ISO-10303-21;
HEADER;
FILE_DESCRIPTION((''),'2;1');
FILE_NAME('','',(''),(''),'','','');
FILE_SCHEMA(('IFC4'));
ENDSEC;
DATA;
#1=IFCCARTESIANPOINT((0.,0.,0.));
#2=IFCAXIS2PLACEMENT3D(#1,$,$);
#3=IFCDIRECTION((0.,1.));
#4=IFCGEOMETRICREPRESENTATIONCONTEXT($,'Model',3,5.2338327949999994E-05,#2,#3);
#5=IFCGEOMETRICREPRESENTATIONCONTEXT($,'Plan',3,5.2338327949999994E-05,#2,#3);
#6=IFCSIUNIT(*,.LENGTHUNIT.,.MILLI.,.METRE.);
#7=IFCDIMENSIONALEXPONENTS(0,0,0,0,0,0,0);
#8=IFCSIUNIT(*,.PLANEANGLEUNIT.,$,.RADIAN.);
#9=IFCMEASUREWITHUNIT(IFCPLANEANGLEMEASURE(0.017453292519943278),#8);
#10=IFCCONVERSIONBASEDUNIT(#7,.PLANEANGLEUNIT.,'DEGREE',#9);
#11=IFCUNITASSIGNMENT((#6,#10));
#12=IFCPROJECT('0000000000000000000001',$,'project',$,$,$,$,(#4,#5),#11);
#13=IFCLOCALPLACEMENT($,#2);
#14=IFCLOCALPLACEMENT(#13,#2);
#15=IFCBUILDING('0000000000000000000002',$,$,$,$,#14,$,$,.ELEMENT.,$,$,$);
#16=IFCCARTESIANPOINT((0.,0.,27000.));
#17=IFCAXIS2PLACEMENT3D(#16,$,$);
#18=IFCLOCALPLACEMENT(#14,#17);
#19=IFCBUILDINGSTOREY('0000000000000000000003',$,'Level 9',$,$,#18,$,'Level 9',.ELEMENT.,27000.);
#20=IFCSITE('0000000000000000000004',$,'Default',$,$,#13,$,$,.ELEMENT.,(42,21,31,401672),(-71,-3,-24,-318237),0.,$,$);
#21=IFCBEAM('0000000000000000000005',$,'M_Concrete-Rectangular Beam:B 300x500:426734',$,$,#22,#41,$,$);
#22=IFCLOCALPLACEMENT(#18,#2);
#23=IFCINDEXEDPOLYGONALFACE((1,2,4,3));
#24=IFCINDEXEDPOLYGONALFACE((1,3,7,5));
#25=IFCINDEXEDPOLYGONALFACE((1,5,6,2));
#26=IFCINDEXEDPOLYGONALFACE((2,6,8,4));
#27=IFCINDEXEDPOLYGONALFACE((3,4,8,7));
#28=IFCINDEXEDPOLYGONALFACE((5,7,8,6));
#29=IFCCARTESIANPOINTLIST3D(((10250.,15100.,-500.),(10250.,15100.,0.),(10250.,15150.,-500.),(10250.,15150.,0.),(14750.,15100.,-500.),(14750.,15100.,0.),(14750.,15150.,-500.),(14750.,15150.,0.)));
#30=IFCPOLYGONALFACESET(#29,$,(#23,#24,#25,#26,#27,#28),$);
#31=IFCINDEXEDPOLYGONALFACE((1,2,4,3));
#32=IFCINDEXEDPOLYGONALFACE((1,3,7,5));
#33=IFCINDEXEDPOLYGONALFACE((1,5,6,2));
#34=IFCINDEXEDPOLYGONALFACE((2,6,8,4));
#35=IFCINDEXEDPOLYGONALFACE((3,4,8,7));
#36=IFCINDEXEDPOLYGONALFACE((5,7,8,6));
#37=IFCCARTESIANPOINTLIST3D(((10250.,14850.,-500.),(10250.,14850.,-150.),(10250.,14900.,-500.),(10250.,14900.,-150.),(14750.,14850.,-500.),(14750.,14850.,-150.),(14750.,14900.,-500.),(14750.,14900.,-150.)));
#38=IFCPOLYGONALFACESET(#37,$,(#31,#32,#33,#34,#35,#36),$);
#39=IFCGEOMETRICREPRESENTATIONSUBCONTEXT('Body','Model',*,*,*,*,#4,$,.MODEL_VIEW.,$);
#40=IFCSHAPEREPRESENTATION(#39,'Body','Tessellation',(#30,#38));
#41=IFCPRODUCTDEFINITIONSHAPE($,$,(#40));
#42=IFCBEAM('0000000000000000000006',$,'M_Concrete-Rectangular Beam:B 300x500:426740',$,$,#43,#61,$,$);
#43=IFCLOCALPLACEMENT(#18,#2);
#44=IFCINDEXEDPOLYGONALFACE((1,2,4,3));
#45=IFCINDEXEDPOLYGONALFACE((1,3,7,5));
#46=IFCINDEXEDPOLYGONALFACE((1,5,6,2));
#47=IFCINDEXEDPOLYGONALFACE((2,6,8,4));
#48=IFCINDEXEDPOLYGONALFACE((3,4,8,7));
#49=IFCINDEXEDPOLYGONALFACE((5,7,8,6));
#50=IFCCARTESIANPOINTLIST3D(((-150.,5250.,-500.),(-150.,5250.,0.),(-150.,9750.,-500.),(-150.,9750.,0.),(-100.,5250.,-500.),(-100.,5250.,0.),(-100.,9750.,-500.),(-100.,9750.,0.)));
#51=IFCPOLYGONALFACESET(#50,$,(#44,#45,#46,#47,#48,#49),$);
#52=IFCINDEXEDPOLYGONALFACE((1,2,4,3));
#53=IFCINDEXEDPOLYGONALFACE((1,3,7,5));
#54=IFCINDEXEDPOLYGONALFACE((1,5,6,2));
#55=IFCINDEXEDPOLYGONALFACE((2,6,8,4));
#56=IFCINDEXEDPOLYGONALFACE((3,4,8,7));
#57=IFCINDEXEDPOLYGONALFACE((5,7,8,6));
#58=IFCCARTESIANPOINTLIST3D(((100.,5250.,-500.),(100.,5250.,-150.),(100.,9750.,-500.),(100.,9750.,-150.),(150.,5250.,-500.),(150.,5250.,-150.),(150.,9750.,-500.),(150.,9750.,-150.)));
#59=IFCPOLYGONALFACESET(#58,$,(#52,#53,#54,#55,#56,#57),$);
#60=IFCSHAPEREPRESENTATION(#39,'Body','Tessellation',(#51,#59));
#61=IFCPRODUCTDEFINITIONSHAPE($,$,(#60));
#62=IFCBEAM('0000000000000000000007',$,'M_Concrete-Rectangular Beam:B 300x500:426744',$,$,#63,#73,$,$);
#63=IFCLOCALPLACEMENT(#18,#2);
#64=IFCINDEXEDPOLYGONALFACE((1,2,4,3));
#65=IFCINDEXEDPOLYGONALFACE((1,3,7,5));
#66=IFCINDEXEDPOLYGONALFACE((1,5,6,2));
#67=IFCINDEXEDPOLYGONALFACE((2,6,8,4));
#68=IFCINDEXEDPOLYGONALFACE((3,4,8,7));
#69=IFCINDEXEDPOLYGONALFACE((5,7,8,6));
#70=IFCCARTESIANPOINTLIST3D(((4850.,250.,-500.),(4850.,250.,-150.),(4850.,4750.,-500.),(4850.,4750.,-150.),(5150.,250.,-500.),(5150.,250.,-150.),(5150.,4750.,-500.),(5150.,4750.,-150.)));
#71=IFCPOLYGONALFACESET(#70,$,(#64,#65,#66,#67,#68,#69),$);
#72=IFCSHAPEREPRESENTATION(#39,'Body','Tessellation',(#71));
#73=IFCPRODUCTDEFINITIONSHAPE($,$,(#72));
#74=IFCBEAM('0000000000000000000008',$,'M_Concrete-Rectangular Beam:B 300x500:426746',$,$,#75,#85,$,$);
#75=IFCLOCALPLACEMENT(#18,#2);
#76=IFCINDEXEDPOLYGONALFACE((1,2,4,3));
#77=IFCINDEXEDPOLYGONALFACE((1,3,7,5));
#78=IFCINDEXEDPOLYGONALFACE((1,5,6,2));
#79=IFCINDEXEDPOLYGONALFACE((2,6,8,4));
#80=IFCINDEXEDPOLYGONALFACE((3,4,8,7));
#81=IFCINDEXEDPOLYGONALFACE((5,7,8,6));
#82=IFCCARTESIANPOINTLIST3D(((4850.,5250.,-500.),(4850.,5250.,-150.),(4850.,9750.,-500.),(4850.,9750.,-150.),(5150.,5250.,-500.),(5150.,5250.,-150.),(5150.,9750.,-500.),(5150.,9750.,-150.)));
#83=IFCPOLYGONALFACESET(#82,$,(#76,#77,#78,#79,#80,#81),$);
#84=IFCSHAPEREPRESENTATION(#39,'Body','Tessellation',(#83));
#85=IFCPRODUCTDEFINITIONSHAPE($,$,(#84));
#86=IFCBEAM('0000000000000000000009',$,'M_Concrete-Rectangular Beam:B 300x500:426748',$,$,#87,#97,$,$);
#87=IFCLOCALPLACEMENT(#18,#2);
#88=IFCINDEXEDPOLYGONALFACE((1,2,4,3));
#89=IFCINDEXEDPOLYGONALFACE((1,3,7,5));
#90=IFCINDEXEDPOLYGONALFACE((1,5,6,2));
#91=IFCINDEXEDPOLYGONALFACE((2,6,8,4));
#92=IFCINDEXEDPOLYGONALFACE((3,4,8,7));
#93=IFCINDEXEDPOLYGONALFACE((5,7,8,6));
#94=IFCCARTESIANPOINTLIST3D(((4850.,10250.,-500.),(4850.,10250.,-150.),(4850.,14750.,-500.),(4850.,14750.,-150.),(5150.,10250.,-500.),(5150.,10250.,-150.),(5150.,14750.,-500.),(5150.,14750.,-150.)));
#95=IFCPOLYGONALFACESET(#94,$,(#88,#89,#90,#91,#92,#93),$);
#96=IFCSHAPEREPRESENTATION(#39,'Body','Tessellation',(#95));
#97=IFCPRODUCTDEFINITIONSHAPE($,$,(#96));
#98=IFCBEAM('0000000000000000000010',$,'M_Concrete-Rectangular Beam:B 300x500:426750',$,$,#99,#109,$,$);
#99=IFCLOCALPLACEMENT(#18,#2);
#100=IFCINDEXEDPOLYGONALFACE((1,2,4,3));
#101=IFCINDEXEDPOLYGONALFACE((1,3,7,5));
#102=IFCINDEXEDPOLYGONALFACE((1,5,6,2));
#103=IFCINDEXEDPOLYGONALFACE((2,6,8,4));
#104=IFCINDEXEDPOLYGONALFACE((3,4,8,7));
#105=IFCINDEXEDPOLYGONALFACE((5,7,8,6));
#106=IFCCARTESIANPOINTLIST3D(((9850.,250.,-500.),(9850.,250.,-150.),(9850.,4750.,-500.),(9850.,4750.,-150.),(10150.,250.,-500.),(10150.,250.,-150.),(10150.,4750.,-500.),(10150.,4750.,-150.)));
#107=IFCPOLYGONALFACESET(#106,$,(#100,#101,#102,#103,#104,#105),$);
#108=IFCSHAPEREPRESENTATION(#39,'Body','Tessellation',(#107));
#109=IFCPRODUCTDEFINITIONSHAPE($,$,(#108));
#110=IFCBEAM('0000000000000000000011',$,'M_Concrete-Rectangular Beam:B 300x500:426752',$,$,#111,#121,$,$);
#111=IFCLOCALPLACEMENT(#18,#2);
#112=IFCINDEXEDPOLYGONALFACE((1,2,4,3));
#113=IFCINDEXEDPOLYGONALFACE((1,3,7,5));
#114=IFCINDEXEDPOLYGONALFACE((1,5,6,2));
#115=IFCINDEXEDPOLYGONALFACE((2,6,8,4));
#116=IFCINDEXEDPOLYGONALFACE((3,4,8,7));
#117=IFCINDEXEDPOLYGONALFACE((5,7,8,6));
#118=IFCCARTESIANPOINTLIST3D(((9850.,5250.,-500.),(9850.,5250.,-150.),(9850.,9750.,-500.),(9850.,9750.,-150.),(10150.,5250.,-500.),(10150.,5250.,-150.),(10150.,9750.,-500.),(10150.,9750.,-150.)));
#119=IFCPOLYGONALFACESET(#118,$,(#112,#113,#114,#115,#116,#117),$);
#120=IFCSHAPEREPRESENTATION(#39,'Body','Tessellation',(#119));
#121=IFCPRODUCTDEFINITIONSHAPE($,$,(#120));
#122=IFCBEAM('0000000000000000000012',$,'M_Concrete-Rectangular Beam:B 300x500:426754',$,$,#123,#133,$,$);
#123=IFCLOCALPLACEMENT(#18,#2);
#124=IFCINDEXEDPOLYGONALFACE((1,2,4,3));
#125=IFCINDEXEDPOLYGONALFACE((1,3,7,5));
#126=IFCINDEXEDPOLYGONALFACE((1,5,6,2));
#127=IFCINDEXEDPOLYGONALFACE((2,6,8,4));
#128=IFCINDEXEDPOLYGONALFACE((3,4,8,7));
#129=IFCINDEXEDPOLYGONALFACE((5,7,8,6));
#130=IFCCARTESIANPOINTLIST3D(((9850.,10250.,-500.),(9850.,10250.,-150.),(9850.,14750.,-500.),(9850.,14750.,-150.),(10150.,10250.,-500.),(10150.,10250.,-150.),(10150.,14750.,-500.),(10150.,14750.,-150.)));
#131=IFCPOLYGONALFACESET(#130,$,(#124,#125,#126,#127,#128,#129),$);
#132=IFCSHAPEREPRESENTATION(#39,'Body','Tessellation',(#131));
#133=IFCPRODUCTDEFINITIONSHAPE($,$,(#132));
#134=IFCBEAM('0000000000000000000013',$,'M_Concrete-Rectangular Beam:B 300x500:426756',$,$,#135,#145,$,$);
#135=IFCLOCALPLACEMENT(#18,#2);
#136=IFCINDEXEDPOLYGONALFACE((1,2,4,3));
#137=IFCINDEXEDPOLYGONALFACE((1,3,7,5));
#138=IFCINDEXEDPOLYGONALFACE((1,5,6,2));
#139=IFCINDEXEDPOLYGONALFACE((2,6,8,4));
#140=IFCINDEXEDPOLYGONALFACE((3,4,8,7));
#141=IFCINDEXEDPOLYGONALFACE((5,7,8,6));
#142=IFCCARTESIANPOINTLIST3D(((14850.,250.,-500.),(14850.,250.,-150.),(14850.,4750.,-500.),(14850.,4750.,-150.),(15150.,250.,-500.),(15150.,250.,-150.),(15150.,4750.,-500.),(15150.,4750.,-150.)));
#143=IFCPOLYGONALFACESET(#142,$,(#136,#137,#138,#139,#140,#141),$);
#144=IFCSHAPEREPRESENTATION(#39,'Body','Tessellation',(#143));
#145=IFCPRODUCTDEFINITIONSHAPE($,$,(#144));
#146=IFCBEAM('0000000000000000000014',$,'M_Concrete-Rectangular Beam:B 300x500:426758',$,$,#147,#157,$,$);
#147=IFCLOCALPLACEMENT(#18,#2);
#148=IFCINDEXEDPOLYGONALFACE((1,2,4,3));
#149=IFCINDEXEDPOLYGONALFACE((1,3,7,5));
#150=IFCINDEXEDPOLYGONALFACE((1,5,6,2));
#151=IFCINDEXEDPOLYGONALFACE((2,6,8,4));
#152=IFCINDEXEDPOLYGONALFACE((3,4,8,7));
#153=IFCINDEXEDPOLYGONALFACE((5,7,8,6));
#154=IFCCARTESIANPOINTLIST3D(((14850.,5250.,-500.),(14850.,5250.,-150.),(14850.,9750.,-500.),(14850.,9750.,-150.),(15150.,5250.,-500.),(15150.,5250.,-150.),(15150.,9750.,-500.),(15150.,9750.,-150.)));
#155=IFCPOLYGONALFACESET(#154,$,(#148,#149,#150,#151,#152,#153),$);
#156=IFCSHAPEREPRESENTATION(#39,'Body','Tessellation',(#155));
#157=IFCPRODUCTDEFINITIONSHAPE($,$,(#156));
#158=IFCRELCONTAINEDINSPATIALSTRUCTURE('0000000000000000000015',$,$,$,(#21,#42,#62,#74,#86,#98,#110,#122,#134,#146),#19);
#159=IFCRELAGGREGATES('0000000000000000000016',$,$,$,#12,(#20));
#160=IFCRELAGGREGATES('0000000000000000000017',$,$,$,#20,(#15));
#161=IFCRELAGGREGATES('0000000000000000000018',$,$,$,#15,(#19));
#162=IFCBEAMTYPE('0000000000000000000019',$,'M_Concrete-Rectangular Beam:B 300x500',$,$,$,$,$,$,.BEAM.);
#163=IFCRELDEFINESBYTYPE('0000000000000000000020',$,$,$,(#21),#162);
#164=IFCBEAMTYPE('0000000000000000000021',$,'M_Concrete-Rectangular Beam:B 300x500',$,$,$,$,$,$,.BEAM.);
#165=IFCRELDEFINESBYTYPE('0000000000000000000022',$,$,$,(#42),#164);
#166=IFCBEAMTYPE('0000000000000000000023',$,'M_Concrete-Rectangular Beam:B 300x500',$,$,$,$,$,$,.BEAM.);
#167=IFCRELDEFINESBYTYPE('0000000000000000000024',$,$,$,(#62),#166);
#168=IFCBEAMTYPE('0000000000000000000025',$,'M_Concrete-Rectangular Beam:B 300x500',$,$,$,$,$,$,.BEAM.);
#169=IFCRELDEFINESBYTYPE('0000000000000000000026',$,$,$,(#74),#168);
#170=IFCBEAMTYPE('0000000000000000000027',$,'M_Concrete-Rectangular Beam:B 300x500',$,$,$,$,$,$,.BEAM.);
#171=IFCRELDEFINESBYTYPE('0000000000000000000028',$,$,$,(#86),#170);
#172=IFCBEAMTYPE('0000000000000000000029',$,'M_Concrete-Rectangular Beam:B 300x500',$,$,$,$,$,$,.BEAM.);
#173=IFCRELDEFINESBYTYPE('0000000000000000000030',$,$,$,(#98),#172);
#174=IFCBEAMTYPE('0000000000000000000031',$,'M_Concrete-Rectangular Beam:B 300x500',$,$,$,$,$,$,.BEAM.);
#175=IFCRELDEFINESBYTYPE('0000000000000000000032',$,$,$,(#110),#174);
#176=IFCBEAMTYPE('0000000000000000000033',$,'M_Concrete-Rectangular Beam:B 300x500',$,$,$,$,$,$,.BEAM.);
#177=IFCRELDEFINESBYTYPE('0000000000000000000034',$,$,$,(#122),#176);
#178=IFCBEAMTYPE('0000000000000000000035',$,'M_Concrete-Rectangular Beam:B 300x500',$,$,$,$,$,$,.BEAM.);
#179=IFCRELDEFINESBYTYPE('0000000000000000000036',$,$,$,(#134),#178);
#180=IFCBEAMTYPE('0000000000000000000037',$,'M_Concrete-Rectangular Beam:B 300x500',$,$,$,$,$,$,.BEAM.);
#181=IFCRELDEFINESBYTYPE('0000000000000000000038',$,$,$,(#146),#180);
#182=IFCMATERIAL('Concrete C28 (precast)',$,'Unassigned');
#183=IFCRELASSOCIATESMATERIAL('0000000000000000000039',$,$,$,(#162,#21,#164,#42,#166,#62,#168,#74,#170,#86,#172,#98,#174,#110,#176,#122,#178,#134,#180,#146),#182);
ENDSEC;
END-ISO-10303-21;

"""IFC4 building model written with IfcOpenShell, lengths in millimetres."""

from ifc_helpers import new_model, entity, si_unit, converted_unit, direction, frame, origin, place, context, subcontext, project, spatial, indexed_curve, outline, extrude, source, transform, mapped, material, type_object, type_shapes, element, save


model = new_model("IFC4")

# Units and contexts
model_context = context("Model", 3, precision=5.2338327949999994e-05, world=origin(), true_north=direction((0.0, 1.0)))
plan_context = context("Plan", 3, precision=5.2338327949999994e-05, world=origin(), true_north=direction((0.0, 1.0)))
body_context = subcontext(model_context, "Body", "Model", "MODEL_VIEW")
ifc_project = project(units=[si_unit("LENGTHUNIT", "METRE", prefix="MILLI"), converted_unit("PLANEANGLEUNIT", "DEGREE", entity("IfcPlaneAngleMeasure", 0.017453292519943278), si_unit("PLANEANGLEUNIT", "RADIAN"), dimensions=[0, 0, 0, 0, 0, 0, 0])], contexts=[model_context, plan_context])

# Site, building, storey
site_placement = place(None, origin())
site = spatial("IfcSite", under=ifc_project, at=site_placement, Name="Default", CompositionType="ELEMENT", RefLatitude=(42, 21, 31, 401672), RefLongitude=(-71, -3, -24, -318237), RefElevation=0.0)
building_placement = place(site_placement, origin())
building = spatial("IfcBuilding", under=site, at=building_placement, CompositionType="ELEMENT")
storey_placement = place(building_placement, frame((0.0, 0.0, 27000.0)))
storey = spatial("IfcBuildingStorey", under=building, at=storey_placement, Name="Level 9", LongName="Level 9", CompositionType="ELEMENT", Elevation=27000.0)

# Beams
ifc_material = material(Name="Concrete C28 (precast)", Category="Unassigned")
beam_type_1 = type_object("IfcBeamType", Name="M_Concrete-Rectangular Beam:B 300x500", PredefinedType="BEAM", material=ifc_material)
shared_shape_1 = source(origin(), body_context, "Body", "SweptSolid", [
    extrude(outline(indexed_curve([(-250.0, -25.0), (250.0, -25.0), (250.0, 25.0), (-250.0, 25.0), (-250.0, -25.0)], self_intersect=False)), frame((10250.0, 15125.0, 26750.0), z_axis=(1.0, 0.0, 0.0), x_axis=(0.0, 0.0, -1.0)), (0.0, 0.0, 1.0), 4500.0),
    extrude(outline(indexed_curve([(-175.0, -25.0), (175.0, -25.0), (175.0, 25.0), (-175.0, 25.0), (-175.0, -25.0)], self_intersect=False)), frame((10250.0, 14875.0, 26675.0), z_axis=(1.0, 0.0, 0.0), x_axis=(0.0, 0.0, -1.0)), (0.0, 0.0, 1.0), 4500.0),
])
type_shapes(beam_type_1, [shared_shape_1])
beam_1_placement = place(storey_placement, frame((0.0, 0.0, -27000.0)))
element("IfcBeam", 1, at=beam_1_placement, inside=storey, type_object=beam_type_1, material=ifc_material, Name="M_Concrete-Rectangular Beam:B 300x500:426734", context=body_context, shape_type="MappedRepresentation", body=[
    mapped(shared_shape_1, transform((0.0, 0.0, 0.0), scale=1.0)),
])
beam_type_2 = type_object("IfcBeamType", Name="M_Concrete-Rectangular Beam:B 300x500", PredefinedType="BEAM", material=ifc_material)
shared_shape_2 = source(origin(), body_context, "Body", "SweptSolid", [
    extrude(outline(indexed_curve([(-25.0, -250.0), (25.0, -250.0), (25.0, 250.0), (-25.0, 250.0), (-25.0, -250.0)], self_intersect=False)), frame((-125.0, 5250.0, 26750.0), z_axis=(0.0, 1.0, 0.0), x_axis=(-1.0, 0.0, 0.0)), (0.0, 0.0, 1.0), 4500.0),
    extrude(outline(indexed_curve([(-25.0, -175.0), (25.0, -175.0), (25.0, 175.0), (-25.0, 175.0), (-25.0, -175.0)], self_intersect=False)), frame((125.0, 5250.0, 26675.0), z_axis=(0.0, 1.0, 0.0), x_axis=(-1.0, 0.0, 0.0)), (0.0, 0.0, 1.0), 4500.0),
])
type_shapes(beam_type_2, [shared_shape_2])
beam_2_placement = place(storey_placement, frame((0.0, 0.0, -27000.0)))
element("IfcBeam", 2, at=beam_2_placement, inside=storey, type_object=beam_type_2, material=ifc_material, Name="M_Concrete-Rectangular Beam:B 300x500:426740", context=body_context, shape_type="MappedRepresentation", body=[
    mapped(shared_shape_2, transform((0.0, 0.0, 0.0), scale=1.0)),
])
beam_type_3 = type_object("IfcBeamType", Name="M_Concrete-Rectangular Beam:B 300x500", PredefinedType="BEAM", material=ifc_material)
shared_shape_3 = source(origin(), body_context, "Body", "SweptSolid", [
    extrude(outline(indexed_curve([(-150.0, -175.0), (150.0, -175.0), (150.0, 175.0), (-150.0, 175.0), (-150.0, -175.0)], self_intersect=False)), frame((5000.0, 250.0, 26675.0), z_axis=(0.0, 1.0, 0.0), x_axis=(-1.0, 0.0, 0.0)), (0.0, 0.0, 1.0), 4500.0),
])
type_shapes(beam_type_3, [shared_shape_3])
beam_3_placement = place(storey_placement, frame((0.0, 0.0, -27000.0)))
element("IfcBeam", 3, at=beam_3_placement, inside=storey, type_object=beam_type_3, material=ifc_material, Name="M_Concrete-Rectangular Beam:B 300x500:426744", context=body_context, shape_type="MappedRepresentation", body=[
    mapped(shared_shape_3, transform((0.0, 0.0, 0.0), scale=1.0)),
])
beam_type_4 = type_object("IfcBeamType", Name="M_Concrete-Rectangular Beam:B 300x500", PredefinedType="BEAM", material=ifc_material)
shared_shape_4 = source(origin(), body_context, "Body", "SweptSolid", [
    extrude(outline(indexed_curve([(-150.0, -175.0), (150.0, -175.0), (150.0, 175.0), (-150.0, 175.0), (-150.0, -175.0)], self_intersect=False)), frame((5000.0, 5250.0, 26675.0), z_axis=(0.0, 1.0, 0.0), x_axis=(-1.0, 0.0, 0.0)), (0.0, 0.0, 1.0), 4500.0),
])
type_shapes(beam_type_4, [shared_shape_4])
beam_4_placement = place(storey_placement, frame((0.0, 0.0, -27000.0)))
element("IfcBeam", 4, at=beam_4_placement, inside=storey, type_object=beam_type_4, material=ifc_material, Name="M_Concrete-Rectangular Beam:B 300x500:426746", context=body_context, shape_type="MappedRepresentation", body=[
    mapped(shared_shape_4, transform((0.0, 0.0, 0.0), scale=1.0)),
])
beam_type_5 = type_object("IfcBeamType", Name="M_Concrete-Rectangular Beam:B 300x500", PredefinedType="BEAM", material=ifc_material)
shared_shape_5 = source(origin(), body_context, "Body", "SweptSolid", [
    extrude(outline(indexed_curve([(-150.0, -175.0), (150.0, -175.0), (150.0, 175.0), (-150.0, 175.0), (-150.0, -175.0)], self_intersect=False)), frame((5000.0, 10250.0, 26675.0), z_axis=(0.0, 1.0, 0.0), x_axis=(-1.0, 0.0, 0.0)), (0.0, 0.0, 1.0), 4500.0),
])
type_shapes(beam_type_5, [shared_shape_5])
beam_5_placement = place(storey_placement, frame((0.0, 0.0, -27000.0)))
element("IfcBeam", 5, at=beam_5_placement, inside=storey, type_object=beam_type_5, material=ifc_material, Name="M_Concrete-Rectangular Beam:B 300x500:426748", context=body_context, shape_type="MappedRepresentation", body=[
    mapped(shared_shape_5, transform((0.0, 0.0, 0.0), scale=1.0)),
])
beam_type_6 = type_object("IfcBeamType", Name="M_Concrete-Rectangular Beam:B 300x500", PredefinedType="BEAM", material=ifc_material)
shared_shape_6 = source(origin(), body_context, "Body", "SweptSolid", [
    extrude(outline(indexed_curve([(-150.0, -175.0), (150.0, -175.0), (150.0, 175.0), (-150.0, 175.0), (-150.0, -175.0)], self_intersect=False)), frame((10000.0, 250.0, 26675.0), z_axis=(0.0, 1.0, 0.0), x_axis=(-1.0, 0.0, 0.0)), (0.0, 0.0, 1.0), 4500.0),
])
type_shapes(beam_type_6, [shared_shape_6])
beam_6_placement = place(storey_placement, frame((0.0, 0.0, -27000.0)))
element("IfcBeam", 6, at=beam_6_placement, inside=storey, type_object=beam_type_6, material=ifc_material, Name="M_Concrete-Rectangular Beam:B 300x500:426750", context=body_context, shape_type="MappedRepresentation", body=[
    mapped(shared_shape_6, transform((0.0, 0.0, 0.0), scale=1.0)),
])
beam_type_7 = type_object("IfcBeamType", Name="M_Concrete-Rectangular Beam:B 300x500", PredefinedType="BEAM", material=ifc_material)
shared_shape_7 = source(origin(), body_context, "Body", "SweptSolid", [
    extrude(outline(indexed_curve([(-150.0, -175.0), (150.0, -175.0), (150.0, 175.0), (-150.0, 175.0), (-150.0, -175.0)], self_intersect=False)), frame((10000.0, 5250.0, 26675.0), z_axis=(0.0, 1.0, 0.0), x_axis=(-1.0, 0.0, 0.0)), (0.0, 0.0, 1.0), 4500.0),
])
type_shapes(beam_type_7, [shared_shape_7])
beam_7_placement = place(storey_placement, frame((0.0, 0.0, -27000.0)))
element("IfcBeam", 7, at=beam_7_placement, inside=storey, type_object=beam_type_7, material=ifc_material, Name="M_Concrete-Rectangular Beam:B 300x500:426752", context=body_context, shape_type="MappedRepresentation", body=[
    mapped(shared_shape_7, transform((0.0, 0.0, 0.0), scale=1.0)),
])
beam_type_8 = type_object("IfcBeamType", Name="M_Concrete-Rectangular Beam:B 300x500", PredefinedType="BEAM", material=ifc_material)
shared_shape_8 = source(origin(), body_context, "Body", "SweptSolid", [
    extrude(outline(indexed_curve([(-150.0, -175.0), (150.0, -175.0), (150.0, 175.0), (-150.0, 175.0), (-150.0, -175.0)], self_intersect=False)), frame((10000.0, 10250.0, 26675.0), z_axis=(0.0, 1.0, 0.0), x_axis=(-1.0, 0.0, 0.0)), (0.0, 0.0, 1.0), 4500.0),
])
type_shapes(beam_type_8, [shared_shape_8])
beam_8_placement = place(storey_placement, frame((0.0, 0.0, -27000.0)))
element("IfcBeam", 8, at=beam_8_placement, inside=storey, type_object=beam_type_8, material=ifc_material, Name="M_Concrete-Rectangular Beam:B 300x500:426754", context=body_context, shape_type="MappedRepresentation", body=[
    mapped(shared_shape_8, transform((0.0, 0.0, 0.0), scale=1.0)),
])
beam_type_9 = type_object("IfcBeamType", Name="M_Concrete-Rectangular Beam:B 300x500", PredefinedType="BEAM", material=ifc_material)
shared_shape_9 = source(origin(), body_context, "Body", "SweptSolid", [
    extrude(outline(indexed_curve([(-150.0, -175.0), (150.0, -175.0), (150.0, 175.0), (-150.0, 175.0), (-150.0, -175.0)], self_intersect=False)), frame((15000.0, 250.0, 26675.0), z_axis=(0.0, 1.0, 0.0), x_axis=(-1.0, 0.0, 0.0)), (0.0, 0.0, 1.0), 4500.0),
])
type_shapes(beam_type_9, [shared_shape_9])
beam_9_placement = place(storey_placement, frame((0.0, 0.0, -27000.0)))
element("IfcBeam", 9, at=beam_9_placement, inside=storey, type_object=beam_type_9, material=ifc_material, Name="M_Concrete-Rectangular Beam:B 300x500:426756", context=body_context, shape_type="MappedRepresentation", body=[
    mapped(shared_shape_9, transform((0.0, 0.0, 0.0), scale=1.0)),
])
beam_type_10 = type_object("IfcBeamType", Name="M_Concrete-Rectangular Beam:B 300x500", PredefinedType="BEAM", material=ifc_material)
shared_shape_10 = source(origin(), body_context, "Body", "SweptSolid", [
    extrude(outline(indexed_curve([(-150.0, -175.0), (150.0, -175.0), (150.0, 175.0), (-150.0, 175.0), (-150.0, -175.0)], self_intersect=False)), frame((15000.0, 5250.0, 26675.0), z_axis=(0.0, 1.0, 0.0), x_axis=(-1.0, 0.0, 0.0)), (0.0, 0.0, 1.0), 4500.0),
])
type_shapes(beam_type_10, [shared_shape_10])
beam_10_placement = place(storey_placement, frame((0.0, 0.0, -27000.0)))
element("IfcBeam", 10, at=beam_10_placement, inside=storey, type_object=beam_type_10, material=ifc_material, Name="M_Concrete-Rectangular Beam:B 300x500:426758", context=body_context, shape_type="MappedRepresentation", body=[
    mapped(shared_shape_10, transform((0.0, 0.0, 0.0), scale=1.0)),
])

save(model, "model.ifc")
